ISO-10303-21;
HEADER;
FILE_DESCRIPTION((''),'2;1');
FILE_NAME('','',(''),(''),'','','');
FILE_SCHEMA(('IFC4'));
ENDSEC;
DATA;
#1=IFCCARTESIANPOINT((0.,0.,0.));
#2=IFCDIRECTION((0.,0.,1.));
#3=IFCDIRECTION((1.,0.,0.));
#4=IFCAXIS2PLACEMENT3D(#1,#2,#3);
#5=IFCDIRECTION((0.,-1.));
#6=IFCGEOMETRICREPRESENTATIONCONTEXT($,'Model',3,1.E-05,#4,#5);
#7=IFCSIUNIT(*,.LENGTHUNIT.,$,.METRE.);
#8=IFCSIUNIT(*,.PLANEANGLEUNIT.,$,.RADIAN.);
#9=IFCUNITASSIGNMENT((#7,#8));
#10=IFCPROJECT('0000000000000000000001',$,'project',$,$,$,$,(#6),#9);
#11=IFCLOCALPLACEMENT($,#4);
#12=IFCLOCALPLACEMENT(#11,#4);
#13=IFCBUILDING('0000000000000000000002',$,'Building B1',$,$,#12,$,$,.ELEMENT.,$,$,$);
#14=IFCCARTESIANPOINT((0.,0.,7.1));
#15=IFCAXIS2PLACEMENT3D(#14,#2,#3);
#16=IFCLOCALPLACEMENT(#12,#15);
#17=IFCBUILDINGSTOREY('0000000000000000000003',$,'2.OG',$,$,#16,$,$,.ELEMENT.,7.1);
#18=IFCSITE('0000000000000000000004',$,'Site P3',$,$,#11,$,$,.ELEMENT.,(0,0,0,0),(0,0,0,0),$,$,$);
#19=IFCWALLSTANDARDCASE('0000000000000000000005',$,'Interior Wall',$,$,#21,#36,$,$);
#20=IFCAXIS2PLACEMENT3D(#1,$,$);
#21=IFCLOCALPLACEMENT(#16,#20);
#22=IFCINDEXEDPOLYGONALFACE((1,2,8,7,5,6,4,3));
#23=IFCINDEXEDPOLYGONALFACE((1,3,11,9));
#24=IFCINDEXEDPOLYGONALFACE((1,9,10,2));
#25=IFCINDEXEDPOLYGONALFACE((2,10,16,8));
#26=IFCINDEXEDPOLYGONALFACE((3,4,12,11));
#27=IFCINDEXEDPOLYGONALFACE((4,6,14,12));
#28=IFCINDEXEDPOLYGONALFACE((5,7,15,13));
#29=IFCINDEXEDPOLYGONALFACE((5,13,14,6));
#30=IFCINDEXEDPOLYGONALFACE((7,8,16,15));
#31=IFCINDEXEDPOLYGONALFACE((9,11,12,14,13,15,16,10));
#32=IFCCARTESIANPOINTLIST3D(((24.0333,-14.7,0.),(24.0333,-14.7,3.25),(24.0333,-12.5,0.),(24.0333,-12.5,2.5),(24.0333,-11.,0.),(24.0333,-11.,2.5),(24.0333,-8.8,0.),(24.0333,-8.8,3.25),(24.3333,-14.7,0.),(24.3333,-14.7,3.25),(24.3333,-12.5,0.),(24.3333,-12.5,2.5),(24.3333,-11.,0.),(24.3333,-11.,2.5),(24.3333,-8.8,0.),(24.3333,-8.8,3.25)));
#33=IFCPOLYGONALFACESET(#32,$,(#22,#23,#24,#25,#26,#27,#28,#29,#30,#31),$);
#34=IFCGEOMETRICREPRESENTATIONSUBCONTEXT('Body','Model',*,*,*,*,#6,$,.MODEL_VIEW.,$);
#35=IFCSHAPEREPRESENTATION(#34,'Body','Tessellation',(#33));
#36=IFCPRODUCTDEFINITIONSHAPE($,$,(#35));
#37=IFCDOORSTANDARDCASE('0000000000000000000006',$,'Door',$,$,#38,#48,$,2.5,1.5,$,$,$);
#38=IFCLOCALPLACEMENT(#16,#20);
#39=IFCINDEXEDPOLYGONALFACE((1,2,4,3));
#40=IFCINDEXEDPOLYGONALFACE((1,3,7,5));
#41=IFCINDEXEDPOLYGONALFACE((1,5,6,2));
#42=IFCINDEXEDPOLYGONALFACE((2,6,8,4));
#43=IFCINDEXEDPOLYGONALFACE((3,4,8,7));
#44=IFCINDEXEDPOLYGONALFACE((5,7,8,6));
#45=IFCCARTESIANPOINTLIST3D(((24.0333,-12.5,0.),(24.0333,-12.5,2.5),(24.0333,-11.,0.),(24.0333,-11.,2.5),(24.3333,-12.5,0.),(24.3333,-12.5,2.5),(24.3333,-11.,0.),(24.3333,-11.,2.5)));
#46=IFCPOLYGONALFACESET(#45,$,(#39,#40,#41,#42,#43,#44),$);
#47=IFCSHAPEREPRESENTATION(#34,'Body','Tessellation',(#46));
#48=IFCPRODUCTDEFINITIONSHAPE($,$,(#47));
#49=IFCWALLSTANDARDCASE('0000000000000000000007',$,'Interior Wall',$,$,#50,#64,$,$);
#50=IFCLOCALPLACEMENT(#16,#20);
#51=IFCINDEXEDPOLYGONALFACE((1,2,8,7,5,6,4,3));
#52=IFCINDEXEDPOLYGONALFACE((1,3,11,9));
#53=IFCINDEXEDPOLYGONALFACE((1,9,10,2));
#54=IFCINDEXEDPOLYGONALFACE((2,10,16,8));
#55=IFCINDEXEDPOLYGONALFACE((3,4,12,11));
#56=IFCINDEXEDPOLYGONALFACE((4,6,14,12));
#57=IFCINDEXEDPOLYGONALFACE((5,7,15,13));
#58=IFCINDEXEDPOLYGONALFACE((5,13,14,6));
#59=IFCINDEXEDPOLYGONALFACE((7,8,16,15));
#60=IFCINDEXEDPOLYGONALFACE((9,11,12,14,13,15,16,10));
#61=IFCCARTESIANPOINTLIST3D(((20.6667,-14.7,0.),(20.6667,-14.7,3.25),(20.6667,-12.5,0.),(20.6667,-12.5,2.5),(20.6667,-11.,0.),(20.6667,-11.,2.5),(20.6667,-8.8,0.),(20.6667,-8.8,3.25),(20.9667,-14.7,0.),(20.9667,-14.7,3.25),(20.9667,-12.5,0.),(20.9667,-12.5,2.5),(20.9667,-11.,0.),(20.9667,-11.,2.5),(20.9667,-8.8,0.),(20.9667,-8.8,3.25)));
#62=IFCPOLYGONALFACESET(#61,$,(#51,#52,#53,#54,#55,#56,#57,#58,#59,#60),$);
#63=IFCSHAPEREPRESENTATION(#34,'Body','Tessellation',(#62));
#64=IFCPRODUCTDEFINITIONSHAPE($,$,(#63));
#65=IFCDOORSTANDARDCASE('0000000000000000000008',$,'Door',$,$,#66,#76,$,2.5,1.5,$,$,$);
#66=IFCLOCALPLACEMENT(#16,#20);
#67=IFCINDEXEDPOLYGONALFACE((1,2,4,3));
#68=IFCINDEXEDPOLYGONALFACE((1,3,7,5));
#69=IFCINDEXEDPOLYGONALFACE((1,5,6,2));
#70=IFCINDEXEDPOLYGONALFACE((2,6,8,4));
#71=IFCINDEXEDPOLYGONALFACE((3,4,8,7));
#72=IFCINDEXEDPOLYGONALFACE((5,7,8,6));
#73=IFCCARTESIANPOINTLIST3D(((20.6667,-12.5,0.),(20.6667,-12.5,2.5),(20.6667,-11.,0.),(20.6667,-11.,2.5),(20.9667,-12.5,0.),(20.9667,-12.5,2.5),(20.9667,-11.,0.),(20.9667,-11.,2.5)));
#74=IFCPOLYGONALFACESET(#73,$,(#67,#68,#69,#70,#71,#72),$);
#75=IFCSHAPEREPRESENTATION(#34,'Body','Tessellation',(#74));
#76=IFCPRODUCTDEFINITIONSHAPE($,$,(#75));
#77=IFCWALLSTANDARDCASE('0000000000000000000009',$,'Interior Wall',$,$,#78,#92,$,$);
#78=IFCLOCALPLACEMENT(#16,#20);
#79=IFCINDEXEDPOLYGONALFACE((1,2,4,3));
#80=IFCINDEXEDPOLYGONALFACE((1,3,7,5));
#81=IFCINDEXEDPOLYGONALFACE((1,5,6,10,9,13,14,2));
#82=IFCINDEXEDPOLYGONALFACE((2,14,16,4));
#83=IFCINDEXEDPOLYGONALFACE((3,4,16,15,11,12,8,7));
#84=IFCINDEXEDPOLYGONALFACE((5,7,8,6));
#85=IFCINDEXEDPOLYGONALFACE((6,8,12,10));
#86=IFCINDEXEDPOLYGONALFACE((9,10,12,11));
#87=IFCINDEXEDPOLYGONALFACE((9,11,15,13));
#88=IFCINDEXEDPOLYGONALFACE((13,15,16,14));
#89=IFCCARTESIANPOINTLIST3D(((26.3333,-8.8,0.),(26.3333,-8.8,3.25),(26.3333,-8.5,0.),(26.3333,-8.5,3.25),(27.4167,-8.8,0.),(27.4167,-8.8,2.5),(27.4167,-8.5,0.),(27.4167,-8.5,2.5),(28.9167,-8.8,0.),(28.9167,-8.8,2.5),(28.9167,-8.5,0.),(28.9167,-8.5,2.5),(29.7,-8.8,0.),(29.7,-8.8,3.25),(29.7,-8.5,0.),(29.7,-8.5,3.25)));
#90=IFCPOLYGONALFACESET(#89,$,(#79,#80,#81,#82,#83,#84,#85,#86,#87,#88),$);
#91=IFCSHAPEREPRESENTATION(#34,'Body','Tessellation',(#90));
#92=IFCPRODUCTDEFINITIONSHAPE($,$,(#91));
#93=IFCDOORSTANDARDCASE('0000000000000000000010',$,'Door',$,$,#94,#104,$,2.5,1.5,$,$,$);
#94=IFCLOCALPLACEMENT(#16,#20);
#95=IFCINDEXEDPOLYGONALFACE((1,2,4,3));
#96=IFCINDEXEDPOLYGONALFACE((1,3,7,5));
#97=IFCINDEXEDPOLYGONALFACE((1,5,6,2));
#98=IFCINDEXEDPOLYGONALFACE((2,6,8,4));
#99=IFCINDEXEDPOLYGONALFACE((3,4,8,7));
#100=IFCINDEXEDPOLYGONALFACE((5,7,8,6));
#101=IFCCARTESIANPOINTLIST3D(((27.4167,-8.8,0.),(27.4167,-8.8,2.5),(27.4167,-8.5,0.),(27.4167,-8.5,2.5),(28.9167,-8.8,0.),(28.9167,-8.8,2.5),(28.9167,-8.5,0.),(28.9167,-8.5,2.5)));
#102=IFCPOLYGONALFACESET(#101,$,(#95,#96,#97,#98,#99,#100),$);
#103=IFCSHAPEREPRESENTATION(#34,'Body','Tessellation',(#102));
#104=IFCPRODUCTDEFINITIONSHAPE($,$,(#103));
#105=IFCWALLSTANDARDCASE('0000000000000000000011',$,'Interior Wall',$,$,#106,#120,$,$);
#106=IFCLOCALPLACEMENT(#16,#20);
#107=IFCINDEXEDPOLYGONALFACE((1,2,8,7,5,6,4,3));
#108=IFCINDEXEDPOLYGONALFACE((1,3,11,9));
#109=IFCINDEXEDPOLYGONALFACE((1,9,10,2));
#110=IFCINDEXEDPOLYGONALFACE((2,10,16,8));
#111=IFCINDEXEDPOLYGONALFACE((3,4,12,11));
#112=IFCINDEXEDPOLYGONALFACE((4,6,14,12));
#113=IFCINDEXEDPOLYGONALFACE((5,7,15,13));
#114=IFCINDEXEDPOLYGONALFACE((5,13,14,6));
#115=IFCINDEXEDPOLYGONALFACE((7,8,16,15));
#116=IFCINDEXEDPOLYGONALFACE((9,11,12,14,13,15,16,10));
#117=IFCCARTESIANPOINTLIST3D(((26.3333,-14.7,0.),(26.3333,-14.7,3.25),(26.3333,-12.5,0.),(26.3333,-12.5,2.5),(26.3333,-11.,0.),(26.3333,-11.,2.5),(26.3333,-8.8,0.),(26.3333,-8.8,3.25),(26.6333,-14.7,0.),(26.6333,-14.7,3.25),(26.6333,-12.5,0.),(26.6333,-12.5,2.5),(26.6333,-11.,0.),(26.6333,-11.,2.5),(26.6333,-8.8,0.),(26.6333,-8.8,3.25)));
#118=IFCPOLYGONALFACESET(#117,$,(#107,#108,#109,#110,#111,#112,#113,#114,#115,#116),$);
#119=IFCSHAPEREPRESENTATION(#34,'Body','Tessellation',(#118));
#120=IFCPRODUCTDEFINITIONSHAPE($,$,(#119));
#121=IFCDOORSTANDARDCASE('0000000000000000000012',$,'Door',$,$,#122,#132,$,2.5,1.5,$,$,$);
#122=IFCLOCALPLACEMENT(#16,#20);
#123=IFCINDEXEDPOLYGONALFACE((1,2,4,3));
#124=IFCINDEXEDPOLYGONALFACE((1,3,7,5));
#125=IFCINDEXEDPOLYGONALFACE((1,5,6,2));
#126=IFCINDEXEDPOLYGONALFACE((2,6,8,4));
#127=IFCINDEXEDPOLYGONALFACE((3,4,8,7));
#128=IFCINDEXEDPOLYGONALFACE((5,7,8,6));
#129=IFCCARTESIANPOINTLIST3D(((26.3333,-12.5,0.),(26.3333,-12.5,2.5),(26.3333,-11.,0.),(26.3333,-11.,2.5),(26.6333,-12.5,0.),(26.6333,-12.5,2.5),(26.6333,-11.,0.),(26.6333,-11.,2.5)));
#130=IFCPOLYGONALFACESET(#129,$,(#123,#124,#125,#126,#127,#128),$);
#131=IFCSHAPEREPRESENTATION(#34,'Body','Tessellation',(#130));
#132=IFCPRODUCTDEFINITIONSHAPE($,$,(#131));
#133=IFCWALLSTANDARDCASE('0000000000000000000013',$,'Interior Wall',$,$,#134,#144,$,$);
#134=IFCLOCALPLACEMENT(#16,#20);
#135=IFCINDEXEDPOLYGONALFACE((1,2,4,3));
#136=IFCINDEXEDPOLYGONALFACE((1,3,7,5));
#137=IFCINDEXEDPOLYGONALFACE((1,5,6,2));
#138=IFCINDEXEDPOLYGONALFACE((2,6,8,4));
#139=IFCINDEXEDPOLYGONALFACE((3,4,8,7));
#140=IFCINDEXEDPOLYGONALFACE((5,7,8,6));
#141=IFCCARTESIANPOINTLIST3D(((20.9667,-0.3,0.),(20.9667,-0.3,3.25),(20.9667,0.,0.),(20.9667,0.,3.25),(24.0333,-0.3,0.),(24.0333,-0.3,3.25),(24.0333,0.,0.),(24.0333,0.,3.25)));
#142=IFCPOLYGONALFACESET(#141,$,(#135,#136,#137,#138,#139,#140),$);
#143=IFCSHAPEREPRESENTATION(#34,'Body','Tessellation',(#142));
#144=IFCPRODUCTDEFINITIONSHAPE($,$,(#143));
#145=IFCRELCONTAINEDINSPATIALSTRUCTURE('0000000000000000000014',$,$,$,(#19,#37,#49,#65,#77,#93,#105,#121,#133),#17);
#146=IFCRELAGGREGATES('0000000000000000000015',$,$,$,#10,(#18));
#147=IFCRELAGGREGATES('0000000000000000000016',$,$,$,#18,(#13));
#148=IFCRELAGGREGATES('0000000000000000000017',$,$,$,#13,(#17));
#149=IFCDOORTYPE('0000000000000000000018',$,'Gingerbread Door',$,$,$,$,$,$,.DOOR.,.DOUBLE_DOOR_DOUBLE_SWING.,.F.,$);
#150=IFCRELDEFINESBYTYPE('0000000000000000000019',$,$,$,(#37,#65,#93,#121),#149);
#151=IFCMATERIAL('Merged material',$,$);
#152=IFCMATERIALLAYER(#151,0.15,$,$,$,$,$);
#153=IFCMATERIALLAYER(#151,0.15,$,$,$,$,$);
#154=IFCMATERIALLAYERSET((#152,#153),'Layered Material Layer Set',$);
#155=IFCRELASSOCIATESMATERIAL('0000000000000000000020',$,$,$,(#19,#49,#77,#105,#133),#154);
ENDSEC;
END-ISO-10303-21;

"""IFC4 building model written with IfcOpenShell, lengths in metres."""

from ifc_helpers import new_model, si_unit, direction, frame, origin_with_axes, place, context, subcontext, project, spatial, polyline, outline, extrude, source, transform, mapped, material, layer, layer_set, layer_usage, type_object, element, fill, save


model = new_model("IFC4")

# Units and contexts
model_context = context("Model", 3, precision=1e-05, world=origin_with_axes(), true_north=direction((0.0, -1.0)))
body_context = subcontext(model_context, "Body", "Model", "MODEL_VIEW")
ifc_project = project(units=[si_unit("LENGTHUNIT", "METRE"), si_unit("PLANEANGLEUNIT", "RADIAN")], contexts=[model_context])

# Site, building, storey
site_placement = place(None, origin_with_axes())
site = spatial("IfcSite", under=ifc_project, at=site_placement, Name="Site P3", CompositionType="ELEMENT", RefLatitude=(0, 0, 0, 0), RefLongitude=(0, 0, 0, 0))
building_placement = place(site_placement, origin_with_axes())
building = spatial("IfcBuilding", under=site, at=building_placement, Name="Building B1", CompositionType="ELEMENT")
storey_placement = place(building_placement, frame((0.0, 0.0, 7.1), z_axis=(0.0, 0.0, 1.0), x_axis=(1.0, 0.0, 0.0)))
storey = spatial("IfcBuildingStorey", under=building, at=storey_placement, Name="2.OG", CompositionType="ELEMENT", Elevation=7.1)

# Shared definitions
ifc_material = material(Name="Merged material")

# Walls, openings, doors
ifc_layer_1 = layer(ifc_material, 0.15)
ifc_layer_2 = layer(ifc_material, 0.15)
ifc_layer_set_1 = layer_set([ifc_layer_1, ifc_layer_2], Name="Layered Material Layer Set")
ifc_layer_usage_1 = layer_usage(ifc_layer_set_1, "AXIS2", "POSITIVE", -0.15)
door_type = type_object("IfcDoorType", Name="Gingerbread Door", OperationType="DOUBLE_DOOR_DOUBLE_SWING", ParameterTakesPrecedence=False, PredefinedType="DOOR")
shared_shape_1 = source(origin_with_axes(), body_context, "Body", "SweptSolid", [
    extrude(outline(polyline([(0.0, 0.0), (0.0, 1.5), (2.5, 1.5), (2.5, 0.0), (0.0, 0.0)])), frame((0.0, -0.15, 0.0), z_axis=(0.0, 1.0, 0.0), x_axis=(0.0, 0.0, 1.0)), (0.0, 0.0, 1.0), 0.3),
])
wall_1_placement = place(storey_placement, frame((24.1833, -8.8, 0.0), z_axis=(0.0, 0.0, 1.0), x_axis=(0.0, -1.0, 0.0)))
wall_1 = element("IfcWallStandardCase", 1, at=wall_1_placement, inside=storey, material=ifc_layer_usage_1, Name="Interior Wall", context=body_context, shape_type="SweptSolid", body=[
    extrude(outline(polyline([(0.0, 0.15), (5.9, 0.15), (5.9, -0.15), (0.0, -0.15), (0.0, 0.15)])), origin_with_axes(), (0.0, 0.0, 1.0), 3.25),
])
opening_1_placement = place(wall_1_placement, frame((2.2, 0.0, 0.0), z_axis=(0.0, 0.0, 1.0), x_axis=(1.0, 0.0, 0.0)))
opening_1 = element("IfcOpeningStandardCase", 2, at=opening_1_placement, cuts=wall_1, context=body_context, shape_type="SweptSolid", body=[
    extrude(outline(polyline([(0.0, 0.0), (0.0, 1.5), (2.5, 1.5), (2.5, 0.0), (0.0, 0.0)])), frame((0.0, -0.15, 0.0), z_axis=(0.0, 1.0, 0.0), x_axis=(0.0, 0.0, 1.0)), (0.0, 0.0, 1.0), 0.3),
])
door_1_placement = place(opening_1_placement, origin_with_axes())
door_1 = element("IfcDoorStandardCase", 3, at=door_1_placement, inside=storey, type_object=door_type, Name="Door", OverallHeight=2.5, OverallWidth=1.5, context=body_context, shape_type="MappedRepresentation", body=[
    mapped(shared_shape_1, transform((0.0, 0.0, 0.0))),
])
fill(opening_1, door_1)
wall_2_placement = place(storey_placement, frame((20.8167, -8.8, 0.0), z_axis=(0.0, 0.0, 1.0), x_axis=(0.0, -1.0, 0.0)))
wall_2 = element("IfcWallStandardCase", 4, at=wall_2_placement, inside=storey, material=ifc_layer_usage_1, Name="Interior Wall", context=body_context, shape_type="SweptSolid", body=[
    extrude(outline(polyline([(0.0, 0.15), (5.9, 0.15), (5.9, -0.15), (0.0, -0.15), (0.0, 0.15)])), origin_with_axes(), (0.0, 0.0, 1.0), 3.25),
])
opening_2_placement = place(wall_2_placement, frame((2.2, 0.0, 0.0), z_axis=(0.0, 0.0, 1.0), x_axis=(1.0, 0.0, 0.0)))
opening_2 = element("IfcOpeningStandardCase", 5, at=opening_2_placement, cuts=wall_2, context=body_context, shape_type="SweptSolid", body=[
    extrude(outline(polyline([(0.0, 0.0), (0.0, 1.5), (2.5, 1.5), (2.5, 0.0), (0.0, 0.0)])), frame((0.0, -0.15, 0.0), z_axis=(0.0, 1.0, 0.0), x_axis=(0.0, 0.0, 1.0)), (0.0, 0.0, 1.0), 0.3),
])
door_2_placement = place(opening_2_placement, origin_with_axes())
door_2 = element("IfcDoorStandardCase", 6, at=door_2_placement, inside=storey, type_object=door_type, Name="Door", OverallHeight=2.5, OverallWidth=1.5, context=body_context, shape_type="MappedRepresentation", body=[
    mapped(shared_shape_1, transform((0.0, 0.0, 0.0))),
])
fill(opening_2, door_2)
wall_3_placement = place(storey_placement, frame((26.3333, -8.65, 0.0), z_axis=(0.0, 0.0, 1.0), x_axis=(1.0, 0.0, 0.0)))
wall_3 = element("IfcWallStandardCase", 7, at=wall_3_placement, inside=storey, material=ifc_layer_usage_1, Name="Interior Wall", context=body_context, shape_type="SweptSolid", body=[
    extrude(outline(polyline([(0.0, 0.15), (3.3667, 0.15), (3.3667, -0.15), (0.0, -0.15), (0.0, 0.15)])), origin_with_axes(), (0.0, 0.0, 1.0), 3.25),
])
opening_3_placement = place(wall_3_placement, frame((1.0833, 0.0, 0.0), z_axis=(0.0, 0.0, 1.0), x_axis=(1.0, 0.0, 0.0)))
opening_3 = element("IfcOpeningStandardCase", 8, at=opening_3_placement, cuts=wall_3, context=body_context, shape_type="SweptSolid", body=[
    extrude(outline(polyline([(0.0, 0.0), (0.0, 1.5), (2.5, 1.5), (2.5, 0.0), (0.0, 0.0)])), frame((0.0, -0.15, 0.0), z_axis=(0.0, 1.0, 0.0), x_axis=(0.0, 0.0, 1.0)), (0.0, 0.0, 1.0), 0.3),
])
door_3_placement = place(opening_3_placement, origin_with_axes())
door_3 = element("IfcDoorStandardCase", 9, at=door_3_placement, inside=storey, type_object=door_type, Name="Door", OverallHeight=2.5, OverallWidth=1.5, context=body_context, shape_type="MappedRepresentation", body=[
    mapped(shared_shape_1, transform((0.0, 0.0, 0.0))),
])
fill(opening_3, door_3)
wall_4_placement = place(storey_placement, frame((26.4833, -8.8, 0.0), z_axis=(0.0, 0.0, 1.0), x_axis=(0.0, -1.0, 0.0)))
wall_4 = element("IfcWallStandardCase", 10, at=wall_4_placement, inside=storey, material=ifc_layer_usage_1, Name="Interior Wall", context=body_context, shape_type="SweptSolid", body=[
    extrude(outline(polyline([(0.0, 0.15), (5.9, 0.15), (5.9, -0.15), (0.0, -0.15), (0.0, 0.15)])), origin_with_axes(), (0.0, 0.0, 1.0), 3.25),
])
opening_4_placement = place(wall_4_placement, frame((2.2, 0.0, 0.0), z_axis=(0.0, 0.0, 1.0), x_axis=(1.0, 0.0, 0.0)))
opening_4 = element("IfcOpeningStandardCase", 11, at=opening_4_placement, cuts=wall_4, context=body_context, shape_type="SweptSolid", body=[
    extrude(outline(polyline([(0.0, 0.0), (0.0, 1.5), (2.5, 1.5), (2.5, 0.0), (0.0, 0.0)])), frame((0.0, -0.15, 0.0), z_axis=(0.0, 1.0, 0.0), x_axis=(0.0, 0.0, 1.0)), (0.0, 0.0, 1.0), 0.3),
])
door_4_placement = place(opening_4_placement, origin_with_axes())
door_4 = element("IfcDoorStandardCase", 12, at=door_4_placement, inside=storey, type_object=door_type, Name="Door", OverallHeight=2.5, OverallWidth=1.5, context=body_context, shape_type="MappedRepresentation", body=[
    mapped(shared_shape_1, transform((0.0, 0.0, 0.0))),
])
fill(opening_4, door_4)

# Wall
wall_5_placement = place(storey_placement, frame((20.9667, -0.15, 0.0), z_axis=(0.0, 0.0, 1.0), x_axis=(1.0, 0.0, 0.0)))
element("IfcWallStandardCase", 13, at=wall_5_placement, inside=storey, material=ifc_layer_usage_1, Name="Interior Wall", context=body_context, shape_type="SweptSolid", body=[
    extrude(outline(polyline([(0.0, 0.15), (3.0667, 0.15), (3.0667, -0.15), (0.0, -0.15), (0.0, 0.15)])), origin_with_axes(), (0.0, 0.0, 1.0), 3.25),
])

save(model, "model.ifc")
